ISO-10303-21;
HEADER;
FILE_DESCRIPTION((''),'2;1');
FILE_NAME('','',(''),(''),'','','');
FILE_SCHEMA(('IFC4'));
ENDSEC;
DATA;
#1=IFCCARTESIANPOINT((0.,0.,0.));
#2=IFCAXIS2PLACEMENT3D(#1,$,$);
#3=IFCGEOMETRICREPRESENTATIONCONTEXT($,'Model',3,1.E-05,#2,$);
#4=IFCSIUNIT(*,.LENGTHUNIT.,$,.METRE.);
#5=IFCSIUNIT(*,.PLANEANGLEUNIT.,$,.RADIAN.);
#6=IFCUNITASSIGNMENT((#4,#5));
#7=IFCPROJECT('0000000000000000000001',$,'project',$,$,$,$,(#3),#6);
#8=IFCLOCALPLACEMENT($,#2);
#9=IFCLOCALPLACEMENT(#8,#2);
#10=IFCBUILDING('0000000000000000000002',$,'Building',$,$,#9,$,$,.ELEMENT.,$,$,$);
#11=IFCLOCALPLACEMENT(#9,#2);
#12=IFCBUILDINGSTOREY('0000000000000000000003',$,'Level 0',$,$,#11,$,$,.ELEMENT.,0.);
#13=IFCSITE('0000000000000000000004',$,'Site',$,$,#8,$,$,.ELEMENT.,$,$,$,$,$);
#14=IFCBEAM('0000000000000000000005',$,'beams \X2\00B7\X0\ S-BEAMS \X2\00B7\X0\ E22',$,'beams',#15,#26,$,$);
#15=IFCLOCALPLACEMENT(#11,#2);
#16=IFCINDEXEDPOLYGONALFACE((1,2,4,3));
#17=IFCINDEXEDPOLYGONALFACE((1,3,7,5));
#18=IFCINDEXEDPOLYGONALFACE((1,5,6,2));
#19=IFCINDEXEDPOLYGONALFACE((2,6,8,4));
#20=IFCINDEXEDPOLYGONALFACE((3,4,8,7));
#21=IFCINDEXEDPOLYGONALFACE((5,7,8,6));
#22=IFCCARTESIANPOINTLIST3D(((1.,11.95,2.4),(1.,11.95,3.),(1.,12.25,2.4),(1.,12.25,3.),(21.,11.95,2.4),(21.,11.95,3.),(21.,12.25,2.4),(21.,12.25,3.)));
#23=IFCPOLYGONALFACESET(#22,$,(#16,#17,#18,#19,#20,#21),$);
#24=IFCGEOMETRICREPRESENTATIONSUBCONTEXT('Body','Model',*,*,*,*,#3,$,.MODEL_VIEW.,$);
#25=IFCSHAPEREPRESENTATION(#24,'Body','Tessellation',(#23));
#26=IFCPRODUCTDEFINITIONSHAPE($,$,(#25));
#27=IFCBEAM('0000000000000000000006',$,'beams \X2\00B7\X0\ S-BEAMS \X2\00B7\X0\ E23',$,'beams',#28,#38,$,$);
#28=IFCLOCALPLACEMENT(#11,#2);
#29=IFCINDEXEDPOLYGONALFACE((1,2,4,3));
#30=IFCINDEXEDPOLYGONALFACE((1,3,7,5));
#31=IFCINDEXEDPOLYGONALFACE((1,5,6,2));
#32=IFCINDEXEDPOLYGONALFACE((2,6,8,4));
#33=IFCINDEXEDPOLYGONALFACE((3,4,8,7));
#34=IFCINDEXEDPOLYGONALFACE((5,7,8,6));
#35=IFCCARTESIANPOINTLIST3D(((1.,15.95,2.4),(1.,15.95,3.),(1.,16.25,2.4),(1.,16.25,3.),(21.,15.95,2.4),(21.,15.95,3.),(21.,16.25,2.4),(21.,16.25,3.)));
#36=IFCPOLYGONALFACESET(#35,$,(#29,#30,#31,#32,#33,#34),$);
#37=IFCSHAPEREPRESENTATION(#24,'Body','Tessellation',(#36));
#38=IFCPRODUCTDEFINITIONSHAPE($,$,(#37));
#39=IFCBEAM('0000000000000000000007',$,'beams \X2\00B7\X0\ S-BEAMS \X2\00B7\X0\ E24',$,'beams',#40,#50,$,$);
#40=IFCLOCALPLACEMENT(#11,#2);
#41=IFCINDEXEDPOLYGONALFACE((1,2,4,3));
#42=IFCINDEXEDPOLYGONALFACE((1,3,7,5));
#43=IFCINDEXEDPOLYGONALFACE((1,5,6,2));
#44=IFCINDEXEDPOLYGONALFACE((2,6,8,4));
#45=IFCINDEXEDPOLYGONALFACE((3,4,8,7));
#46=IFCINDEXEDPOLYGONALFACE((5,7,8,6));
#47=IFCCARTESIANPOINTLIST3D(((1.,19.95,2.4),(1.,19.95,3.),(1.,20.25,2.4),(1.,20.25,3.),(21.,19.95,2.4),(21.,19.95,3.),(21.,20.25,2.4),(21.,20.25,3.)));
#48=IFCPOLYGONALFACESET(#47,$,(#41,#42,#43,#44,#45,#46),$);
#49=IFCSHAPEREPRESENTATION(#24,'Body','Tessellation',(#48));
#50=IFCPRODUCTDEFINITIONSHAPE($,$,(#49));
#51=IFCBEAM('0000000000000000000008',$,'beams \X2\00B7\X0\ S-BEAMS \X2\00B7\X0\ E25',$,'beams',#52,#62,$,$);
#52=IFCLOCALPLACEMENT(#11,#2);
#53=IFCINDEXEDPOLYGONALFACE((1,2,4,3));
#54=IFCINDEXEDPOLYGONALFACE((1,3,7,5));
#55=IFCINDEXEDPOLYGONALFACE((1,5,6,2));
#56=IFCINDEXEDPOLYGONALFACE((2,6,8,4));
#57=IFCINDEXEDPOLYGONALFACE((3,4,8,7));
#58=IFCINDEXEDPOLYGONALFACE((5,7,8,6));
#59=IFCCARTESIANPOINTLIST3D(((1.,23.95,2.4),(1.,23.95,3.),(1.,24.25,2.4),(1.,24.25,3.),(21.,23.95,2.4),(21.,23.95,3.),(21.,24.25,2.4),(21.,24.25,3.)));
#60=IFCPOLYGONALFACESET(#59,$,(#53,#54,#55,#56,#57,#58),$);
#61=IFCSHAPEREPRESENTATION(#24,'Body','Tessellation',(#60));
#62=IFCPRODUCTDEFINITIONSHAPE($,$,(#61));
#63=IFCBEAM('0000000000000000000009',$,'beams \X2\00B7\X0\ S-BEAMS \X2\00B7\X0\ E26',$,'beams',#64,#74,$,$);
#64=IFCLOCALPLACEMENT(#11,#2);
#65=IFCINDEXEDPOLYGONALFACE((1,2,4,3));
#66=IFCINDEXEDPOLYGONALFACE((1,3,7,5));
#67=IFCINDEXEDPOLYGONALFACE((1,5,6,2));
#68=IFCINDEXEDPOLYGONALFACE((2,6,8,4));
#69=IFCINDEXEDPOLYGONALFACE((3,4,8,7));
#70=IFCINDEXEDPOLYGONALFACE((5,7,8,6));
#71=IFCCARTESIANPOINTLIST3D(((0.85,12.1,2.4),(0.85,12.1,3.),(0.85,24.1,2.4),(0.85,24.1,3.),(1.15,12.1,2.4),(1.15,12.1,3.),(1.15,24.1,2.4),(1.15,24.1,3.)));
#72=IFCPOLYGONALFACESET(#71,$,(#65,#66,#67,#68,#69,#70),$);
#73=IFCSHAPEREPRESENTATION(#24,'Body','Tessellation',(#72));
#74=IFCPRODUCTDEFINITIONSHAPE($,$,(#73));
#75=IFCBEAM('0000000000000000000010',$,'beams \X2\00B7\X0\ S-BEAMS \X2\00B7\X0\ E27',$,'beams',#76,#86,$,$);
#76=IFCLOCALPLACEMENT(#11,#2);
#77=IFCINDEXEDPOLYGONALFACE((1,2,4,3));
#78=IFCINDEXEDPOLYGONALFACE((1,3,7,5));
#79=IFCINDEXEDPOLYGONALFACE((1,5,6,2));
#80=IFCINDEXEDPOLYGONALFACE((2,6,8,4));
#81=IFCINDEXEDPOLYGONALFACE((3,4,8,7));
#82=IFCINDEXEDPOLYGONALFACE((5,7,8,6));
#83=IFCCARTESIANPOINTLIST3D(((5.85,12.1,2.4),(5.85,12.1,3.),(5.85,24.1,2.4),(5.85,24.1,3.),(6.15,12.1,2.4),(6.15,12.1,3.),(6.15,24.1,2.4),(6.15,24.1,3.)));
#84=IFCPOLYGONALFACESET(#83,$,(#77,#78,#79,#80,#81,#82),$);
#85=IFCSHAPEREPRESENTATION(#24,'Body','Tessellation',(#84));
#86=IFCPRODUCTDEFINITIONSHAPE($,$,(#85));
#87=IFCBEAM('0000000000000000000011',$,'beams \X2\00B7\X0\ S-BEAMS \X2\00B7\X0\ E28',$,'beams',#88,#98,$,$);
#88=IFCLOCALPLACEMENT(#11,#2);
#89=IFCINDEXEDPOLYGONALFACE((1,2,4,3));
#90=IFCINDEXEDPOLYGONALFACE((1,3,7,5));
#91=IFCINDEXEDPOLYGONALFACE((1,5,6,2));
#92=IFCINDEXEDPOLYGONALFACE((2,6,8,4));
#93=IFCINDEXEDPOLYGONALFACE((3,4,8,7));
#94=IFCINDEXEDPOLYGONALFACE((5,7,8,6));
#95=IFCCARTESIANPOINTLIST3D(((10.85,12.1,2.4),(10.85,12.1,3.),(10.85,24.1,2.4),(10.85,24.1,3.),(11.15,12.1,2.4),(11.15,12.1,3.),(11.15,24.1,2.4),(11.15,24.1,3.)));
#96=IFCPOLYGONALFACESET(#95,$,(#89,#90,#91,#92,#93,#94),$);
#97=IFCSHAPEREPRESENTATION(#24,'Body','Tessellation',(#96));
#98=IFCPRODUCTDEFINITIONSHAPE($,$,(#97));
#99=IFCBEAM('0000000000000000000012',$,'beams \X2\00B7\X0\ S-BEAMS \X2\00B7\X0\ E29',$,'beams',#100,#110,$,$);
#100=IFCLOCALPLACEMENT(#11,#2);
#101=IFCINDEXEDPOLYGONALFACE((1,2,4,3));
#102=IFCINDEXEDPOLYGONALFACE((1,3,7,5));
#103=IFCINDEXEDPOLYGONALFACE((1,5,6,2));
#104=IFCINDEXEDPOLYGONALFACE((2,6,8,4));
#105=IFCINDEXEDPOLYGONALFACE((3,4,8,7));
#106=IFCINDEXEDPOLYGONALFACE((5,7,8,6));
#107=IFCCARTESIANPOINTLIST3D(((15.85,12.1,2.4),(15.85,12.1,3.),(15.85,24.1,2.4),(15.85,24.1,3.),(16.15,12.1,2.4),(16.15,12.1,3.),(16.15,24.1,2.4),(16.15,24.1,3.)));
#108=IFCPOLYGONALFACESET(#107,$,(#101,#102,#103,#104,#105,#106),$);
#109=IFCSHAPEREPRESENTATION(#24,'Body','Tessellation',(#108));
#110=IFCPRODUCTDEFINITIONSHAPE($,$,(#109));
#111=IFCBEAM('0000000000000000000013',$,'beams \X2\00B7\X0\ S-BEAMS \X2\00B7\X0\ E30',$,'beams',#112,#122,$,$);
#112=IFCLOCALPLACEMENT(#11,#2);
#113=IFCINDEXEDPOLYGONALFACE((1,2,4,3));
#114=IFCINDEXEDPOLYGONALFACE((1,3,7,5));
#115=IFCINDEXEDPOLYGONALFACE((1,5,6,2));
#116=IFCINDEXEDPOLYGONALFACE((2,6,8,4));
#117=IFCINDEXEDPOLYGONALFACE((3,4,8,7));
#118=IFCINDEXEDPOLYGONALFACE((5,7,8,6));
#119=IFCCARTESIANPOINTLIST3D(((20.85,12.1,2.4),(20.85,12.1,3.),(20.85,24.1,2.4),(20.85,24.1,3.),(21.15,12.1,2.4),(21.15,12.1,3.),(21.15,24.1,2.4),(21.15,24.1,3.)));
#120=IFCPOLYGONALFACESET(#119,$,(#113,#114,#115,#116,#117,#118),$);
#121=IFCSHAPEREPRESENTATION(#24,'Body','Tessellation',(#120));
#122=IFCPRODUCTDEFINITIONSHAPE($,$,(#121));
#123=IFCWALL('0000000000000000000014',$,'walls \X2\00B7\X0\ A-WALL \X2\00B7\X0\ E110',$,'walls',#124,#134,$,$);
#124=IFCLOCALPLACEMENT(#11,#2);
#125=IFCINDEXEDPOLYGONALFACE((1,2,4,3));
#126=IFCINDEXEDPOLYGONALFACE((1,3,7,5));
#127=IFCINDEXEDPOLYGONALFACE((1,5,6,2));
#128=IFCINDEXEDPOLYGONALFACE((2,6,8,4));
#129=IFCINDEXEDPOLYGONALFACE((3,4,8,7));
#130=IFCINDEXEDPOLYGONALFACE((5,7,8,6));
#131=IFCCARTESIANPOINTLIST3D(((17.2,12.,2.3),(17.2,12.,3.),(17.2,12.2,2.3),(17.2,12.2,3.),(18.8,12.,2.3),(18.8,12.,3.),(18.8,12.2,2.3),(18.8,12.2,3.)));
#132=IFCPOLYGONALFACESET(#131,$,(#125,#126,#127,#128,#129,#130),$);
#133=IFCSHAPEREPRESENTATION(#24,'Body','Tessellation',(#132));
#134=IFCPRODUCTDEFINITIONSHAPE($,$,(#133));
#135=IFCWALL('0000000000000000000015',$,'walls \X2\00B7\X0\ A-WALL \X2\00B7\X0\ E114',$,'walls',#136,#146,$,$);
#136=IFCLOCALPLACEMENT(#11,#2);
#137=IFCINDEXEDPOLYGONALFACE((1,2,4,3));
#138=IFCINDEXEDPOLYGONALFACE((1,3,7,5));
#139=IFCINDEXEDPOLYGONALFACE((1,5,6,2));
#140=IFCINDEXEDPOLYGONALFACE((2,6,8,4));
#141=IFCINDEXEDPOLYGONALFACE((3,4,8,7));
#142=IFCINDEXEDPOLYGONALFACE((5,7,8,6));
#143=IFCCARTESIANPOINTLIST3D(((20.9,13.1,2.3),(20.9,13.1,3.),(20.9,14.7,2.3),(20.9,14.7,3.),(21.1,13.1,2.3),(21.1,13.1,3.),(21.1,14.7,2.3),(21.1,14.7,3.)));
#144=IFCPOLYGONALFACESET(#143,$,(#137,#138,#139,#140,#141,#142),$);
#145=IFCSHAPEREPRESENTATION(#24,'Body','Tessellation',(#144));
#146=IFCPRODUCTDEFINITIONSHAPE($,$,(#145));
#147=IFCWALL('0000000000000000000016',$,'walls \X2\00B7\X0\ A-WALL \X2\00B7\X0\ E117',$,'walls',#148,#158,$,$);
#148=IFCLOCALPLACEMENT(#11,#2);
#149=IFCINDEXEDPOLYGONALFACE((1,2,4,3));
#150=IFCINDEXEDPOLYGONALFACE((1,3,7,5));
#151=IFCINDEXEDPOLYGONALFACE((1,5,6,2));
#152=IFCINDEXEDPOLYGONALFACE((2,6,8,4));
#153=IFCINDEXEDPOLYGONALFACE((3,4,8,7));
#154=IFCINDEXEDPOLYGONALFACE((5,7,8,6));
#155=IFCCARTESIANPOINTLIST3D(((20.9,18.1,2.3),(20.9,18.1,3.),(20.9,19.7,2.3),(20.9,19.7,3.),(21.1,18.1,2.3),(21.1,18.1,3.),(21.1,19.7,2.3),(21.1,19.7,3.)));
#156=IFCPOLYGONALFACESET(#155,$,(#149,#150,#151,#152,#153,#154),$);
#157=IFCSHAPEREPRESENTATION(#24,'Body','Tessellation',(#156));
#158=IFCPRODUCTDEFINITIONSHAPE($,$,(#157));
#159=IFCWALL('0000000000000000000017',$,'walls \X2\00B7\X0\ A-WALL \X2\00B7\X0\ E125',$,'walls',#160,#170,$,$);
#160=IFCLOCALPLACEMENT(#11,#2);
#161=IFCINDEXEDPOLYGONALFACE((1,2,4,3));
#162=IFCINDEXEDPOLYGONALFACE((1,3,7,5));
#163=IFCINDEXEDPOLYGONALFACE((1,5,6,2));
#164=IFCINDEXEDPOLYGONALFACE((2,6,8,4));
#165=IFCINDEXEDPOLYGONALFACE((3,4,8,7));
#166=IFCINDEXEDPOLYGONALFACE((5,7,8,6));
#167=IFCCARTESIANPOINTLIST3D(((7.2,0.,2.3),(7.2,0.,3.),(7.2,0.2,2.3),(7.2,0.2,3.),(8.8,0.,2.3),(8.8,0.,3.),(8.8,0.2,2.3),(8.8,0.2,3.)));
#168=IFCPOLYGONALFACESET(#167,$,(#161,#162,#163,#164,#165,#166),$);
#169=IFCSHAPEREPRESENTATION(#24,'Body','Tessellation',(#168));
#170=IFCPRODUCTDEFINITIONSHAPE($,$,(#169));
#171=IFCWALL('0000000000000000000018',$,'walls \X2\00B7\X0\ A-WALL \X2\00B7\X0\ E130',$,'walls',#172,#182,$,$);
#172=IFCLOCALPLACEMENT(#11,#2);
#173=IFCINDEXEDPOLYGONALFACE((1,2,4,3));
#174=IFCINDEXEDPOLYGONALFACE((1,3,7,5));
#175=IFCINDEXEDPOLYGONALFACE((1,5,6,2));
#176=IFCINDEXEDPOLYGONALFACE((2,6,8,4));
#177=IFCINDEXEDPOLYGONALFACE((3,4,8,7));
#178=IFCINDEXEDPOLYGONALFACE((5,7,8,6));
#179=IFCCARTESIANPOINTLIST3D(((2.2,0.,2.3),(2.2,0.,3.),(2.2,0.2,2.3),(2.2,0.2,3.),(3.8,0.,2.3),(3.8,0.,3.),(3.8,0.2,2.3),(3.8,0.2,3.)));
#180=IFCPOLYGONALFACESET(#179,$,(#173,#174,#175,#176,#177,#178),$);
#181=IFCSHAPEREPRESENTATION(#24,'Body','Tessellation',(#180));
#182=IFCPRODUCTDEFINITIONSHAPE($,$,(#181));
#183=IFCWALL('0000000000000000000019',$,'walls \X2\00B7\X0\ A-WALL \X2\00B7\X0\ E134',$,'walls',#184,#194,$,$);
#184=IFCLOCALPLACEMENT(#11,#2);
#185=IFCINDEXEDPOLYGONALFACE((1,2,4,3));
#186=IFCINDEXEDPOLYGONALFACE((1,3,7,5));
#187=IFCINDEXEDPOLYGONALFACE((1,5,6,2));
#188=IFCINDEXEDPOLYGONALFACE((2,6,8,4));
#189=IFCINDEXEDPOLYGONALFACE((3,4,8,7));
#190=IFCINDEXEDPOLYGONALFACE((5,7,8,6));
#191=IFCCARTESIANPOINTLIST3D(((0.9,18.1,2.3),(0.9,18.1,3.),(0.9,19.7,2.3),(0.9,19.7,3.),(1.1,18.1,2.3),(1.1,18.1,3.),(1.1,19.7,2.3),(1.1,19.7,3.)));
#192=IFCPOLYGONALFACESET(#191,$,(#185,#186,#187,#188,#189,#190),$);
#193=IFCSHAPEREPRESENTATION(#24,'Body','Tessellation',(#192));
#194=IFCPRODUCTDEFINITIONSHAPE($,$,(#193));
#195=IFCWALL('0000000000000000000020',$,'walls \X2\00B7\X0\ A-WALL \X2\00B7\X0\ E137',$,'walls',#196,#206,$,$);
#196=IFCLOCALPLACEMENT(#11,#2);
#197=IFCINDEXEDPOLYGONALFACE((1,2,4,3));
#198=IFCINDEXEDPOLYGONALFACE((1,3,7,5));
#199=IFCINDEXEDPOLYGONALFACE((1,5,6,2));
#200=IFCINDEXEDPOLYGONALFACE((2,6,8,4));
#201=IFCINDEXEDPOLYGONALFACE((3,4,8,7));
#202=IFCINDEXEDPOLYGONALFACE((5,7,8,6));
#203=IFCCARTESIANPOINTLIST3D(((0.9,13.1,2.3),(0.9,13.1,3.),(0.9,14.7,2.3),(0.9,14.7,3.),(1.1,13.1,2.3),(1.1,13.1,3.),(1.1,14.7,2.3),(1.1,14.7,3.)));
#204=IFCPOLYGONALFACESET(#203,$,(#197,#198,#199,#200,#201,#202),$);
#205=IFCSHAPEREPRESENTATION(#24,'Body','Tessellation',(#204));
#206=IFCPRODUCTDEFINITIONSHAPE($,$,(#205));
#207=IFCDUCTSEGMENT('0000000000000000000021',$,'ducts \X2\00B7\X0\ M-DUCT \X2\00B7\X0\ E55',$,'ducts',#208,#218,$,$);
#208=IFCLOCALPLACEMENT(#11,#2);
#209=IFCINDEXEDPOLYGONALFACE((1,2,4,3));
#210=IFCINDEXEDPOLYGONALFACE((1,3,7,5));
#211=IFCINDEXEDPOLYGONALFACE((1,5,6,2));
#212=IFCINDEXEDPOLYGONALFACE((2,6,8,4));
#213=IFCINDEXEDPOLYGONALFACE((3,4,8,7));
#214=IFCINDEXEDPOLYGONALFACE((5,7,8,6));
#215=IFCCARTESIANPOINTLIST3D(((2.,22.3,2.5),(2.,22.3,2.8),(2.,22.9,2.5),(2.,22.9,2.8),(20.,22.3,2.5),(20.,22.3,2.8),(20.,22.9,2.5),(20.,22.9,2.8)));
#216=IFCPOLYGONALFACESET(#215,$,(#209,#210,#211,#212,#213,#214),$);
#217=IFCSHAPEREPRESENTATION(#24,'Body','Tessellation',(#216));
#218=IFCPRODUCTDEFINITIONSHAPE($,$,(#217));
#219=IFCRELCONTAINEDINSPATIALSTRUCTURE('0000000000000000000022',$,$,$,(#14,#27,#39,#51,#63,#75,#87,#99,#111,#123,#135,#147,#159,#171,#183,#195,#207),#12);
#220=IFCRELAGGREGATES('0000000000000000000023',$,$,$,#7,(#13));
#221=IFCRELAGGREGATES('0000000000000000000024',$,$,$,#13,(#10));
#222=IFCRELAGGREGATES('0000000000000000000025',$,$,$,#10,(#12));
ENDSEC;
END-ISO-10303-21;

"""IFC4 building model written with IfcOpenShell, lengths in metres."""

from ifc_helpers import new_model, si_unit, frame, origin, place, context, subcontext, project, spatial, polyline, outline, extrude, element, save


model = new_model("IFC4")

# Units and contexts
model_context = context("Model", 3, precision=1e-05, world=origin())
body_context = subcontext(model_context, "Body", "Model", "MODEL_VIEW")
ifc_project = project(units=[si_unit("LENGTHUNIT", "METRE"), si_unit("PLANEANGLEUNIT", "RADIAN")], contexts=[model_context])

# Site, building, storey
site_placement = place(None, origin())
site = spatial("IfcSite", under=ifc_project, at=site_placement, Name="Site", CompositionType="ELEMENT")
building_placement = place(site_placement, origin())
building = spatial("IfcBuilding", under=site, at=building_placement, Name="Building", CompositionType="ELEMENT")
storey_placement = place(building_placement, origin())
storey = spatial("IfcBuildingStorey", under=building, at=storey_placement, Name="Level 0", CompositionType="ELEMENT", Elevation=0.0)

# Beams
beam_1_placement = place(storey_placement, frame((0.0, 0.0, 2.4)))
element("IfcBeam", 1, at=beam_1_placement, inside=storey, Name="beams · S-BEAMS · E22", ObjectType="beams", context=body_context, shape_type="SweptSolid", body=[
    extrude(outline(polyline([(1.0, 11.95), (21.0, 11.95), (21.0, 12.25), (1.0, 12.25), (1.0, 11.95)])), origin(), (0.0, 0.0, 1.0), 0.6),
])
beam_2_placement = place(storey_placement, frame((0.0, 0.0, 2.4)))
element("IfcBeam", 2, at=beam_2_placement, inside=storey, Name="beams · S-BEAMS · E23", ObjectType="beams", context=body_context, shape_type="SweptSolid", body=[
    extrude(outline(polyline([(1.0, 15.95), (21.0, 15.95), (21.0, 16.25), (1.0, 16.25), (1.0, 15.95)])), origin(), (0.0, 0.0, 1.0), 0.6),
])
beam_3_placement = place(storey_placement, frame((0.0, 0.0, 2.4)))
element("IfcBeam", 3, at=beam_3_placement, inside=storey, Name="beams · S-BEAMS · E24", ObjectType="beams", context=body_context, shape_type="SweptSolid", body=[
    extrude(outline(polyline([(1.0, 19.95), (21.0, 19.95), (21.0, 20.25), (1.0, 20.25), (1.0, 19.95)])), origin(), (0.0, 0.0, 1.0), 0.6),
])
beam_4_placement = place(storey_placement, frame((0.0, 0.0, 2.4)))
element("IfcBeam", 4, at=beam_4_placement, inside=storey, Name="beams · S-BEAMS · E25", ObjectType="beams", context=body_context, shape_type="SweptSolid", body=[
    extrude(outline(polyline([(1.0, 23.95), (21.0, 23.95), (21.0, 24.25), (1.0, 24.25), (1.0, 23.95)])), origin(), (0.0, 0.0, 1.0), 0.6),
])
beam_5_placement = place(storey_placement, frame((0.0, 0.0, 2.4)))
element("IfcBeam", 5, at=beam_5_placement, inside=storey, Name="beams · S-BEAMS · E26", ObjectType="beams", context=body_context, shape_type="SweptSolid", body=[
    extrude(outline(polyline([(1.15, 12.1), (1.15, 24.1), (0.85, 24.1), (0.85, 12.1), (1.15, 12.1)])), origin(), (0.0, 0.0, 1.0), 0.6),
])
beam_6_placement = place(storey_placement, frame((0.0, 0.0, 2.4)))
element("IfcBeam", 6, at=beam_6_placement, inside=storey, Name="beams · S-BEAMS · E27", ObjectType="beams", context=body_context, shape_type="SweptSolid", body=[
    extrude(outline(polyline([(6.15, 12.1), (6.15, 24.1), (5.85, 24.1), (5.85, 12.1), (6.15, 12.1)])), origin(), (0.0, 0.0, 1.0), 0.6),
])
beam_7_placement = place(storey_placement, frame((0.0, 0.0, 2.4)))
element("IfcBeam", 7, at=beam_7_placement, inside=storey, Name="beams · S-BEAMS · E28", ObjectType="beams", context=body_context, shape_type="SweptSolid", body=[
    extrude(outline(polyline([(11.15, 12.1), (11.15, 24.1), (10.85, 24.1), (10.85, 12.1), (11.15, 12.1)])), origin(), (0.0, 0.0, 1.0), 0.6),
])
beam_8_placement = place(storey_placement, frame((0.0, 0.0, 2.4)))
element("IfcBeam", 8, at=beam_8_placement, inside=storey, Name="beams · S-BEAMS · E29", ObjectType="beams", context=body_context, shape_type="SweptSolid", body=[
    extrude(outline(polyline([(16.15, 12.1), (16.15, 24.1), (15.85, 24.1), (15.85, 12.1), (16.15, 12.1)])), origin(), (0.0, 0.0, 1.0), 0.6),
])
beam_9_placement = place(storey_placement, frame((0.0, 0.0, 2.4)))
element("IfcBeam", 9, at=beam_9_placement, inside=storey, Name="beams · S-BEAMS · E30", ObjectType="beams", context=body_context, shape_type="SweptSolid", body=[
    extrude(outline(polyline([(21.15, 12.1), (21.15, 24.1), (20.85, 24.1), (20.85, 12.1), (21.15, 12.1)])), origin(), (0.0, 0.0, 1.0), 0.6),
])

# Walls
wall_1_placement = place(storey_placement, frame((0.0, 0.0, 2.3)))
element("IfcWall", 10, at=wall_1_placement, inside=storey, Name="walls · A-WALL · E110", ObjectType="walls", context=body_context, shape_type="SweptSolid", body=[
    extrude(outline(polyline([(17.2, 12.0), (18.8, 12.0), (18.8, 12.2), (17.2, 12.2), (17.2, 12.0)])), origin(), (0.0, 0.0, 1.0), 0.7),
])
wall_2_placement = place(storey_placement, frame((0.0, 0.0, 2.3)))
element("IfcWall", 11, at=wall_2_placement, inside=storey, Name="walls · A-WALL · E114", ObjectType="walls", context=body_context, shape_type="SweptSolid", body=[
    extrude(outline(polyline([(21.1, 13.1), (21.1, 14.7), (20.9, 14.7), (20.9, 13.1), (21.1, 13.1)])), origin(), (0.0, 0.0, 1.0), 0.7),
])
wall_3_placement = place(storey_placement, frame((0.0, 0.0, 2.3)))
element("IfcWall", 12, at=wall_3_placement, inside=storey, Name="walls · A-WALL · E117", ObjectType="walls", context=body_context, shape_type="SweptSolid", body=[
    extrude(outline(polyline([(21.1, 18.1), (21.1, 19.7), (20.9, 19.7), (20.9, 18.1), (21.1, 18.1)])), origin(), (0.0, 0.0, 1.0), 0.7),
])
wall_4_placement = place(storey_placement, frame((0.0, 0.0, 2.3)))
element("IfcWall", 13, at=wall_4_placement, inside=storey, Name="walls · A-WALL · E125", ObjectType="walls", context=body_context, shape_type="SweptSolid", body=[
    extrude(outline(polyline([(8.8, 0.2), (7.2, 0.2), (7.2, 0.0), (8.8, 0.0), (8.8, 0.2)])), origin(), (0.0, 0.0, 1.0), 0.7),
])
wall_5_placement = place(storey_placement, frame((0.0, 0.0, 2.3)))
element("IfcWall", 14, at=wall_5_placement, inside=storey, Name="walls · A-WALL · E130", ObjectType="walls", context=body_context, shape_type="SweptSolid", body=[
    extrude(outline(polyline([(3.8, 0.2), (2.2, 0.2), (2.2, 0.0), (3.8, 0.0), (3.8, 0.2)])), origin(), (0.0, 0.0, 1.0), 0.7),
])
wall_6_placement = place(storey_placement, frame((0.0, 0.0, 2.3)))
element("IfcWall", 15, at=wall_6_placement, inside=storey, Name="walls · A-WALL · E134", ObjectType="walls", context=body_context, shape_type="SweptSolid", body=[
    extrude(outline(polyline([(0.9, 19.7), (0.9, 18.1), (1.1, 18.1), (1.1, 19.7), (0.9, 19.7)])), origin(), (0.0, 0.0, 1.0), 0.7),
])
wall_7_placement = place(storey_placement, frame((0.0, 0.0, 2.3)))
element("IfcWall", 16, at=wall_7_placement, inside=storey, Name="walls · A-WALL · E137", ObjectType="walls", context=body_context, shape_type="SweptSolid", body=[
    extrude(outline(polyline([(0.9, 14.7), (0.9, 13.1), (1.1, 13.1), (1.1, 14.7), (0.9, 14.7)])), origin(), (0.0, 0.0, 1.0), 0.7),
])

# Duct segment
duct_segment_1_placement = place(storey_placement, frame((0.0, 0.0, 2.5)))
element("IfcDuctSegment", 17, at=duct_segment_1_placement, inside=storey, Name="ducts · M-DUCT · E55", ObjectType="ducts", context=body_context, shape_type="SweptSolid", body=[
    extrude(outline(polyline([(2.0, 22.3), (20.0, 22.3), (20.0, 22.9), (2.0, 22.9), (2.0, 22.3)])), origin(), (0.0, 0.0, 1.0), 0.3),
])

save(model, "model.ifc")
